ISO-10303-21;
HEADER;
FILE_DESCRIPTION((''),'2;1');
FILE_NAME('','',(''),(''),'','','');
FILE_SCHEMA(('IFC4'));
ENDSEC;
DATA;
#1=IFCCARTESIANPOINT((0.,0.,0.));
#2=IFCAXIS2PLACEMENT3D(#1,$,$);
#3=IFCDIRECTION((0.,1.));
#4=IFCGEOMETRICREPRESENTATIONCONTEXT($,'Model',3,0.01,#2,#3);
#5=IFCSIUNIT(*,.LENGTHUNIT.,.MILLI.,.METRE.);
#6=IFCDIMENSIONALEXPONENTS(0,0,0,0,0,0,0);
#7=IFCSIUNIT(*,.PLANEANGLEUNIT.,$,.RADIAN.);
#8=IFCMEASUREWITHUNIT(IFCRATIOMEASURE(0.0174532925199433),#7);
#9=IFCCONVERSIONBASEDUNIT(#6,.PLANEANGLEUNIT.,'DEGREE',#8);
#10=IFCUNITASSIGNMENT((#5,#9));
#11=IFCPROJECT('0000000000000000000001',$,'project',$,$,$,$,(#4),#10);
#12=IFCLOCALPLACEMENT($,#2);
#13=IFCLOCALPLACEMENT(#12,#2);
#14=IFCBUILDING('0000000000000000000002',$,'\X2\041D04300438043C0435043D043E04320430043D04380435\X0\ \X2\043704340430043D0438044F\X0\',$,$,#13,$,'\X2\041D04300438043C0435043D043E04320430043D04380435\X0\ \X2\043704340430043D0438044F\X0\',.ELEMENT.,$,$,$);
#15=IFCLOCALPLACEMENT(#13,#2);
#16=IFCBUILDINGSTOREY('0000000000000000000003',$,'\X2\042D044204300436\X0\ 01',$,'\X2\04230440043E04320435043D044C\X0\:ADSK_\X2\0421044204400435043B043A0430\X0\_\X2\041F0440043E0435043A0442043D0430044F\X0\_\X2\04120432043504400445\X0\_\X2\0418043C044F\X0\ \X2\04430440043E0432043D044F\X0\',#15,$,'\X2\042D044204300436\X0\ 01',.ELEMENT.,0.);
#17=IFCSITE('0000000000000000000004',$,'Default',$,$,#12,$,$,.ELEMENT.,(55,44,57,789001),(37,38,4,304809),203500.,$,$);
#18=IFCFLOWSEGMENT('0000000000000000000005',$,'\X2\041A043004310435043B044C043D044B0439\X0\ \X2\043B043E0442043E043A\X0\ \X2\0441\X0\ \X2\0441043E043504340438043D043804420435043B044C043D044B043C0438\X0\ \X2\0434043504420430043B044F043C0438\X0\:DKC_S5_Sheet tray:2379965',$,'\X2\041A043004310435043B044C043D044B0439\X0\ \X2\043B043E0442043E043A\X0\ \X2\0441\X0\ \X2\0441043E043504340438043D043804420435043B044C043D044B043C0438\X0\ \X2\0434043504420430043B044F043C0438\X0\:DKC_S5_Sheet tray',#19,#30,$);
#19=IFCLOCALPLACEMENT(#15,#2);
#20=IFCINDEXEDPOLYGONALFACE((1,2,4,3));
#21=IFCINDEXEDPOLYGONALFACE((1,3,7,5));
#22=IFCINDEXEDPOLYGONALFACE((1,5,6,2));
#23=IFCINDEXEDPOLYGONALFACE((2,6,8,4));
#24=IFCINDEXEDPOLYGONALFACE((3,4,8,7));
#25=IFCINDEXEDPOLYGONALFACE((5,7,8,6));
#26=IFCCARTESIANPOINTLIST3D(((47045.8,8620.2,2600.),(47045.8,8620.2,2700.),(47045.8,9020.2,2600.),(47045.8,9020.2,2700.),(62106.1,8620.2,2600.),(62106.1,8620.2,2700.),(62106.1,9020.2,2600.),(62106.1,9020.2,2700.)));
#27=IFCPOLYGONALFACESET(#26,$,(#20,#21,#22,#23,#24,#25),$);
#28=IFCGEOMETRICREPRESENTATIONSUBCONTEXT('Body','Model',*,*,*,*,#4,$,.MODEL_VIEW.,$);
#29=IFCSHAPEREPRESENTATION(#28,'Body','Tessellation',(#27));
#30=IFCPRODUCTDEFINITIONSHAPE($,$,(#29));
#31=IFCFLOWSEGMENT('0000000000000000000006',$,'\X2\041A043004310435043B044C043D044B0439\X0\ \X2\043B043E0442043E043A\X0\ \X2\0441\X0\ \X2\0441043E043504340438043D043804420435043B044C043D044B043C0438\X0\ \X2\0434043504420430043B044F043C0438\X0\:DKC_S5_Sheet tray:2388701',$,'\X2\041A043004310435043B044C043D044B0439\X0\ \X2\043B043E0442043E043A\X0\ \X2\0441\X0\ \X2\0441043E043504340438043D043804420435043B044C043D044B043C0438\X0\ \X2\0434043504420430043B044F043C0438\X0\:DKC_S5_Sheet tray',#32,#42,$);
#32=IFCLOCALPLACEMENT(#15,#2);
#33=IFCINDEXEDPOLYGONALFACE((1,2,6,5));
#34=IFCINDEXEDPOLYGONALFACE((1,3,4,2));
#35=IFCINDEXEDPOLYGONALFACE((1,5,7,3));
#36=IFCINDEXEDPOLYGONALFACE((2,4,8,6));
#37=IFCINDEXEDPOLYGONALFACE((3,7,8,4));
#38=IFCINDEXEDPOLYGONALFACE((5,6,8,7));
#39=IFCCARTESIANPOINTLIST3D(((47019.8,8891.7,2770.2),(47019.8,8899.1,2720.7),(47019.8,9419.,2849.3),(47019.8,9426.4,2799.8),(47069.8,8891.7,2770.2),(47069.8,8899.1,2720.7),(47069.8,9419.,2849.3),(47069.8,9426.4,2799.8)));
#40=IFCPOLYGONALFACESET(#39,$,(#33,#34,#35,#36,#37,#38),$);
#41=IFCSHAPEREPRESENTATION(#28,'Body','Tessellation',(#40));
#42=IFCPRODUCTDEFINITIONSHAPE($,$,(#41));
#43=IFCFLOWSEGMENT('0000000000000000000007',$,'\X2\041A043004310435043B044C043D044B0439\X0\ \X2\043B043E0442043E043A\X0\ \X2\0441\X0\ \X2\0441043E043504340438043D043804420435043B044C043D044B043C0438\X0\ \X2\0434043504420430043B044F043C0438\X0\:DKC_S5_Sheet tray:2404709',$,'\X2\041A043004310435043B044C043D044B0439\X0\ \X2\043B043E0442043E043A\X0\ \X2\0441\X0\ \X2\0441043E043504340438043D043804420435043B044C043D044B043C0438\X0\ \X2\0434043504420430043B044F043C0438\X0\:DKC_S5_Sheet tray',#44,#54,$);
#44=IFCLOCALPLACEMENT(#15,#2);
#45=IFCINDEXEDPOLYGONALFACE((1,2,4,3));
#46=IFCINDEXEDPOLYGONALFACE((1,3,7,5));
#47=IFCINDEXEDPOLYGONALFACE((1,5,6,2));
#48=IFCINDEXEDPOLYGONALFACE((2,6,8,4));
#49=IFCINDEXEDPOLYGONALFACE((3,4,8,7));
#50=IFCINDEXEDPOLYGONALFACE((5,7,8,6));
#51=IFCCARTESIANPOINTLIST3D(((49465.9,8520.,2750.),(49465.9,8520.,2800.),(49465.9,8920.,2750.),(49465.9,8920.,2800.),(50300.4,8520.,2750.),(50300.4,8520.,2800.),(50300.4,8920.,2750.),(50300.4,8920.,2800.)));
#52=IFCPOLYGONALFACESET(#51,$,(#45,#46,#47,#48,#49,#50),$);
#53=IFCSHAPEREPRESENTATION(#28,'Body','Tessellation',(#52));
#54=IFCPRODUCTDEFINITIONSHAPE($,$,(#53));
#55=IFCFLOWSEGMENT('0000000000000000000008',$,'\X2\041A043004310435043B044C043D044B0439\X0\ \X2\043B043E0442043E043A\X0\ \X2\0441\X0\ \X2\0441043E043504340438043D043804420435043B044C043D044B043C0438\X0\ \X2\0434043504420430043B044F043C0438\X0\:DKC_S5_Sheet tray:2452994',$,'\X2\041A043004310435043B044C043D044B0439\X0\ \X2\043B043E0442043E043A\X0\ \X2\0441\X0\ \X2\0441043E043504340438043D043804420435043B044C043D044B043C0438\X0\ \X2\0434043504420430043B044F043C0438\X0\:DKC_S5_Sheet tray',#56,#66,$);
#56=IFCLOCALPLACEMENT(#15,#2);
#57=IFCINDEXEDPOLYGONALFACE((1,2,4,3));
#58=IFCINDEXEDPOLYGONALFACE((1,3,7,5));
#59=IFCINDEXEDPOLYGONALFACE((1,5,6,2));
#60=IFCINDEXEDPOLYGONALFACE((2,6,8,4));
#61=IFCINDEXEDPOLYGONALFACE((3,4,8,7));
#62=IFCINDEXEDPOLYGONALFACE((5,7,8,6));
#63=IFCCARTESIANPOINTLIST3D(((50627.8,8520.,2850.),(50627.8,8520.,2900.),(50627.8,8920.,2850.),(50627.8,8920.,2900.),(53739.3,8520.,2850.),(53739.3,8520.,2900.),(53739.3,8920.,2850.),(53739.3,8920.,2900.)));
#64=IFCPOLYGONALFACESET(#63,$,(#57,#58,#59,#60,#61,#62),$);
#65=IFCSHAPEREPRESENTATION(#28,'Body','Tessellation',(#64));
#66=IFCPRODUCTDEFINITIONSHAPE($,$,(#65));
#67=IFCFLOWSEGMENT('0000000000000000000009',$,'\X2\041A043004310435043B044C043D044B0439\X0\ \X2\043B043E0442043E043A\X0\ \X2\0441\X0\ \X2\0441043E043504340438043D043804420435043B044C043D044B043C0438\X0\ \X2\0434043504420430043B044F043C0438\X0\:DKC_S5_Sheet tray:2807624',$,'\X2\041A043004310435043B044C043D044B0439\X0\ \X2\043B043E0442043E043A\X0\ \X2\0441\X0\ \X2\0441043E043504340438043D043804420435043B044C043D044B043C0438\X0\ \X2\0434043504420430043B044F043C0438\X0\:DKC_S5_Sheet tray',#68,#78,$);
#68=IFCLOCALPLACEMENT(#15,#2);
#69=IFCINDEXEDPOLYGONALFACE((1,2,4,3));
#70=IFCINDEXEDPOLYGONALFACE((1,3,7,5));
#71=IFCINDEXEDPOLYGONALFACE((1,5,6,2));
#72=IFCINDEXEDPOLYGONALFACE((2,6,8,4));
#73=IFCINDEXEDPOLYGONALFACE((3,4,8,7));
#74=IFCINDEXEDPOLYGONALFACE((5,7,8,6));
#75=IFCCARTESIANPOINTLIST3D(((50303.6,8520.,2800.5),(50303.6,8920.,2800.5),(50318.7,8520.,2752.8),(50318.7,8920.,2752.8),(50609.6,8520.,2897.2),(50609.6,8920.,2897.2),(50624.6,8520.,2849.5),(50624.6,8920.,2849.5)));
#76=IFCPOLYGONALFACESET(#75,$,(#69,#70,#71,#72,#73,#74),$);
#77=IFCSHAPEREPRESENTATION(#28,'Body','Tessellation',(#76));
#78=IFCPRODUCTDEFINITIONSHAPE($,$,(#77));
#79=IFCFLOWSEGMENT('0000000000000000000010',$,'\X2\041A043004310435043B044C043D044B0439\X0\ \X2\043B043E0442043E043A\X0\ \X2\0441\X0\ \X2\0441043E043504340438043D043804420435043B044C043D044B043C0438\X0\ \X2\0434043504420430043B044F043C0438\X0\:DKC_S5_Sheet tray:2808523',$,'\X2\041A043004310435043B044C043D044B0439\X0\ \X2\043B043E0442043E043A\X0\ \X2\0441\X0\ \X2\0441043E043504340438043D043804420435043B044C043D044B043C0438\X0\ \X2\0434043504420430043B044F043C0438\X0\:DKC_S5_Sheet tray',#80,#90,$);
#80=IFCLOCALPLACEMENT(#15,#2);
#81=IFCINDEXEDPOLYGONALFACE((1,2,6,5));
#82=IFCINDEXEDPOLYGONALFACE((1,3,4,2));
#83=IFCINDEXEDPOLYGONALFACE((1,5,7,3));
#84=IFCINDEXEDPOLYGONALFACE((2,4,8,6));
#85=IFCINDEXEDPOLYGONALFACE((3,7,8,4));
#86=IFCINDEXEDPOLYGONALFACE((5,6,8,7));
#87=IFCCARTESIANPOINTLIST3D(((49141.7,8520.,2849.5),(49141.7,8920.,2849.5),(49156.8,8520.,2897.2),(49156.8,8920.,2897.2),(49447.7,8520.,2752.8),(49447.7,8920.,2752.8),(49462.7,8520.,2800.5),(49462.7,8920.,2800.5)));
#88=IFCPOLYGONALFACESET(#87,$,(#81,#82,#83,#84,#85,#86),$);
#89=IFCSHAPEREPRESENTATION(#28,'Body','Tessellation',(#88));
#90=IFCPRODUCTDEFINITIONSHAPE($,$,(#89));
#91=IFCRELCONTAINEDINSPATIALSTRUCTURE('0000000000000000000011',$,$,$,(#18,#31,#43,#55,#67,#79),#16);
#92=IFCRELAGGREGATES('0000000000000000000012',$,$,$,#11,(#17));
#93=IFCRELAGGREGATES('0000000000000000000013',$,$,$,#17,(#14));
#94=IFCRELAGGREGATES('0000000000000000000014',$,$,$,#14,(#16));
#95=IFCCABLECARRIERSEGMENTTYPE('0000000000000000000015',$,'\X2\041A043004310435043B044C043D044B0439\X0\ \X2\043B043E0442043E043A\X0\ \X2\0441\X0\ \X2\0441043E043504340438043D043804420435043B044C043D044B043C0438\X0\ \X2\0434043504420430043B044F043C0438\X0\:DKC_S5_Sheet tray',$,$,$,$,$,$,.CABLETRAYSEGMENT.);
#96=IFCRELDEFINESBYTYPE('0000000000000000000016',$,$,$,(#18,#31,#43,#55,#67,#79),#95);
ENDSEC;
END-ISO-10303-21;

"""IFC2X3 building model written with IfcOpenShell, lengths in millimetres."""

from ifc_helpers import new_model, entity, si_unit, converted_unit, direction, frame, frame_2d, origin, origin_2d_with_axis, place, context, subcontext, project, spatial, rectangle, extrude, type_object, element, save


model = new_model("IFC2X3")

# Units and contexts
model_context = context("Model", 3, precision=0.01, world=origin(), true_north=direction((0.0, 1.0)))
body_context = subcontext(model_context, "Body", "Model", "MODEL_VIEW")
ifc_project = project(units=[si_unit("LENGTHUNIT", "METRE", prefix="MILLI"), converted_unit("PLANEANGLEUNIT", "DEGREE", entity("IfcRatioMeasure", 0.0174532925199433), si_unit("PLANEANGLEUNIT", "RADIAN"), dimensions=[0, 0, 0, 0, 0, 0, 0])], contexts=[model_context])

# Site, building, storey
site_placement = place(None, origin())
site = spatial("IfcSite", under=ifc_project, at=site_placement, Name="Default", CompositionType="ELEMENT", RefLatitude=(55, 44, 57, 789001), RefLongitude=(37, 38, 4, 304809), RefElevation=203500.0)
building_placement = place(site_placement, origin())
building = spatial("IfcBuilding", under=site, at=building_placement, Name="Наименование здания", LongName="Наименование здания", CompositionType="ELEMENT")
storey_placement = place(building_placement, origin())
storey = spatial("IfcBuildingStorey", under=building, at=storey_placement, Name="Этаж 01", ObjectType="Уровень:ADSK_Стрелка_Проектная_Вверх_Имя уровня", LongName="Этаж 01", CompositionType="ELEMENT", Elevation=0.0)

# Flow segments
cable_carrier_segment_type = type_object("IfcCableCarrierSegmentType", Name="Кабельный лоток с соединительными деталями:DKC_S5_Sheet tray", PredefinedType="CABLETRAYSEGMENT")
flow_segment_1_placement = place(storey_placement, frame((47045.8, 8620.2, 2600.0)))
element("IfcFlowSegment", 1, at=flow_segment_1_placement, inside=storey, type_object=cable_carrier_segment_type, Name="Кабельный лоток с соединительными деталями:DKC_S5_Sheet tray:2379965", ObjectType="Кабельный лоток с соединительными деталями:DKC_S5_Sheet tray", context=body_context, shape_type="SweptSolid", body=[
    extrude(rectangle(XDim=15060.3, YDim=400.0, at=origin_2d_with_axis()), frame((7530.1, 200.0, 0.0), z_axis=(0.0, 0.0, 1.0), x_axis=(-1.0, 0.0, 0.0)), (0.0, 0.0, 1.0), 100.0),
])
flow_segment_2_placement = place(storey_placement, frame((47019.8, 8891.7, 2720.8)))
element("IfcFlowSegment", 2, at=flow_segment_2_placement, inside=storey, type_object=cable_carrier_segment_type, Name="Кабельный лоток с соединительными деталями:DKC_S5_Sheet tray:2388701", ObjectType="Кабельный лоток с соединительными деталями:DKC_S5_Sheet tray", context=body_context, shape_type="SweptSolid", body=[
    extrude(rectangle(XDim=50.0, YDim=533.2, at=frame_2d((0.0, 0.0), x_axis=(0.0, 1.0))), frame((0.0, 267.3, 64.2), z_axis=(1.0, 0.0, 0.0), x_axis=(0.0, -0.988944, -0.148292)), (0.0, 0.0, 1.0), 50.0),
])
flow_segment_3_placement = place(storey_placement, frame((49465.9, 8520.0, 2750.0)))
element("IfcFlowSegment", 3, at=flow_segment_3_placement, inside=storey, type_object=cable_carrier_segment_type, Name="Кабельный лоток с соединительными деталями:DKC_S5_Sheet tray:2404709", ObjectType="Кабельный лоток с соединительными деталями:DKC_S5_Sheet tray", context=body_context, shape_type="SweptSolid", body=[
    extrude(rectangle(XDim=834.5, YDim=400.0, at=origin_2d_with_axis()), frame((417.3, 200.0, 0.0), z_axis=(0.0, 0.0, 1.0), x_axis=(-1.0, 0.0, 0.0)), (0.0, 0.0, 1.0), 50.0),
])
flow_segment_4_placement = place(storey_placement, frame((50627.8, 8520.0, 2850.0)))
element("IfcFlowSegment", 4, at=flow_segment_4_placement, inside=storey, type_object=cable_carrier_segment_type, Name="Кабельный лоток с соединительными деталями:DKC_S5_Sheet tray:2452994", ObjectType="Кабельный лоток с соединительными деталями:DKC_S5_Sheet tray", context=body_context, shape_type="SweptSolid", body=[
    extrude(rectangle(XDim=3111.5, YDim=400.0, at=origin_2d_with_axis()), frame((1555.8, 200.0, 0.0), z_axis=(0.0, 0.0, 1.0), x_axis=(-1.0, 0.0, 0.0)), (0.0, 0.0, 1.0), 50.0),
])
flow_segment_5_placement = place(storey_placement, frame((50303.6, 8520.0, 2752.8)))
element("IfcFlowSegment", 5, at=flow_segment_5_placement, inside=storey, type_object=cable_carrier_segment_type, Name="Кабельный лоток с соединительными деталями:DKC_S5_Sheet tray:2807624", ObjectType="Кабельный лоток с соединительными деталями:DKC_S5_Sheet tray", context=body_context, shape_type="SweptSolid", body=[
    extrude(rectangle(XDim=50.0, YDim=320.9, at=frame_2d((0.0, 0.0), x_axis=(0.0, 1.0))), frame((160.5, 0.0, 72.2), z_axis=(0.0, 1.0, 0.0), x_axis=(-0.953515, 0.0, -0.301344)), (0.0, 0.0, 1.0), 400.0),
])
flow_segment_6_placement = place(storey_placement, frame((49141.7, 8520.0, 2752.8)))
element("IfcFlowSegment", 6, at=flow_segment_6_placement, inside=storey, type_object=cable_carrier_segment_type, Name="Кабельный лоток с соединительными деталями:DKC_S5_Sheet tray:2808523", ObjectType="Кабельный лоток с соединительными деталями:DKC_S5_Sheet tray", context=body_context, shape_type="SweptSolid", body=[
    extrude(rectangle(XDim=50.0, YDim=320.9, at=frame_2d((0.0, 0.0), x_axis=(0.0, 1.0))), frame((160.5, 0.0, 72.2), z_axis=(0.0, 1.0, 0.0), x_axis=(0.953515, 0.0, -0.301344)), (0.0, 0.0, 1.0), 400.0),
])

save(model, "model.ifc")
